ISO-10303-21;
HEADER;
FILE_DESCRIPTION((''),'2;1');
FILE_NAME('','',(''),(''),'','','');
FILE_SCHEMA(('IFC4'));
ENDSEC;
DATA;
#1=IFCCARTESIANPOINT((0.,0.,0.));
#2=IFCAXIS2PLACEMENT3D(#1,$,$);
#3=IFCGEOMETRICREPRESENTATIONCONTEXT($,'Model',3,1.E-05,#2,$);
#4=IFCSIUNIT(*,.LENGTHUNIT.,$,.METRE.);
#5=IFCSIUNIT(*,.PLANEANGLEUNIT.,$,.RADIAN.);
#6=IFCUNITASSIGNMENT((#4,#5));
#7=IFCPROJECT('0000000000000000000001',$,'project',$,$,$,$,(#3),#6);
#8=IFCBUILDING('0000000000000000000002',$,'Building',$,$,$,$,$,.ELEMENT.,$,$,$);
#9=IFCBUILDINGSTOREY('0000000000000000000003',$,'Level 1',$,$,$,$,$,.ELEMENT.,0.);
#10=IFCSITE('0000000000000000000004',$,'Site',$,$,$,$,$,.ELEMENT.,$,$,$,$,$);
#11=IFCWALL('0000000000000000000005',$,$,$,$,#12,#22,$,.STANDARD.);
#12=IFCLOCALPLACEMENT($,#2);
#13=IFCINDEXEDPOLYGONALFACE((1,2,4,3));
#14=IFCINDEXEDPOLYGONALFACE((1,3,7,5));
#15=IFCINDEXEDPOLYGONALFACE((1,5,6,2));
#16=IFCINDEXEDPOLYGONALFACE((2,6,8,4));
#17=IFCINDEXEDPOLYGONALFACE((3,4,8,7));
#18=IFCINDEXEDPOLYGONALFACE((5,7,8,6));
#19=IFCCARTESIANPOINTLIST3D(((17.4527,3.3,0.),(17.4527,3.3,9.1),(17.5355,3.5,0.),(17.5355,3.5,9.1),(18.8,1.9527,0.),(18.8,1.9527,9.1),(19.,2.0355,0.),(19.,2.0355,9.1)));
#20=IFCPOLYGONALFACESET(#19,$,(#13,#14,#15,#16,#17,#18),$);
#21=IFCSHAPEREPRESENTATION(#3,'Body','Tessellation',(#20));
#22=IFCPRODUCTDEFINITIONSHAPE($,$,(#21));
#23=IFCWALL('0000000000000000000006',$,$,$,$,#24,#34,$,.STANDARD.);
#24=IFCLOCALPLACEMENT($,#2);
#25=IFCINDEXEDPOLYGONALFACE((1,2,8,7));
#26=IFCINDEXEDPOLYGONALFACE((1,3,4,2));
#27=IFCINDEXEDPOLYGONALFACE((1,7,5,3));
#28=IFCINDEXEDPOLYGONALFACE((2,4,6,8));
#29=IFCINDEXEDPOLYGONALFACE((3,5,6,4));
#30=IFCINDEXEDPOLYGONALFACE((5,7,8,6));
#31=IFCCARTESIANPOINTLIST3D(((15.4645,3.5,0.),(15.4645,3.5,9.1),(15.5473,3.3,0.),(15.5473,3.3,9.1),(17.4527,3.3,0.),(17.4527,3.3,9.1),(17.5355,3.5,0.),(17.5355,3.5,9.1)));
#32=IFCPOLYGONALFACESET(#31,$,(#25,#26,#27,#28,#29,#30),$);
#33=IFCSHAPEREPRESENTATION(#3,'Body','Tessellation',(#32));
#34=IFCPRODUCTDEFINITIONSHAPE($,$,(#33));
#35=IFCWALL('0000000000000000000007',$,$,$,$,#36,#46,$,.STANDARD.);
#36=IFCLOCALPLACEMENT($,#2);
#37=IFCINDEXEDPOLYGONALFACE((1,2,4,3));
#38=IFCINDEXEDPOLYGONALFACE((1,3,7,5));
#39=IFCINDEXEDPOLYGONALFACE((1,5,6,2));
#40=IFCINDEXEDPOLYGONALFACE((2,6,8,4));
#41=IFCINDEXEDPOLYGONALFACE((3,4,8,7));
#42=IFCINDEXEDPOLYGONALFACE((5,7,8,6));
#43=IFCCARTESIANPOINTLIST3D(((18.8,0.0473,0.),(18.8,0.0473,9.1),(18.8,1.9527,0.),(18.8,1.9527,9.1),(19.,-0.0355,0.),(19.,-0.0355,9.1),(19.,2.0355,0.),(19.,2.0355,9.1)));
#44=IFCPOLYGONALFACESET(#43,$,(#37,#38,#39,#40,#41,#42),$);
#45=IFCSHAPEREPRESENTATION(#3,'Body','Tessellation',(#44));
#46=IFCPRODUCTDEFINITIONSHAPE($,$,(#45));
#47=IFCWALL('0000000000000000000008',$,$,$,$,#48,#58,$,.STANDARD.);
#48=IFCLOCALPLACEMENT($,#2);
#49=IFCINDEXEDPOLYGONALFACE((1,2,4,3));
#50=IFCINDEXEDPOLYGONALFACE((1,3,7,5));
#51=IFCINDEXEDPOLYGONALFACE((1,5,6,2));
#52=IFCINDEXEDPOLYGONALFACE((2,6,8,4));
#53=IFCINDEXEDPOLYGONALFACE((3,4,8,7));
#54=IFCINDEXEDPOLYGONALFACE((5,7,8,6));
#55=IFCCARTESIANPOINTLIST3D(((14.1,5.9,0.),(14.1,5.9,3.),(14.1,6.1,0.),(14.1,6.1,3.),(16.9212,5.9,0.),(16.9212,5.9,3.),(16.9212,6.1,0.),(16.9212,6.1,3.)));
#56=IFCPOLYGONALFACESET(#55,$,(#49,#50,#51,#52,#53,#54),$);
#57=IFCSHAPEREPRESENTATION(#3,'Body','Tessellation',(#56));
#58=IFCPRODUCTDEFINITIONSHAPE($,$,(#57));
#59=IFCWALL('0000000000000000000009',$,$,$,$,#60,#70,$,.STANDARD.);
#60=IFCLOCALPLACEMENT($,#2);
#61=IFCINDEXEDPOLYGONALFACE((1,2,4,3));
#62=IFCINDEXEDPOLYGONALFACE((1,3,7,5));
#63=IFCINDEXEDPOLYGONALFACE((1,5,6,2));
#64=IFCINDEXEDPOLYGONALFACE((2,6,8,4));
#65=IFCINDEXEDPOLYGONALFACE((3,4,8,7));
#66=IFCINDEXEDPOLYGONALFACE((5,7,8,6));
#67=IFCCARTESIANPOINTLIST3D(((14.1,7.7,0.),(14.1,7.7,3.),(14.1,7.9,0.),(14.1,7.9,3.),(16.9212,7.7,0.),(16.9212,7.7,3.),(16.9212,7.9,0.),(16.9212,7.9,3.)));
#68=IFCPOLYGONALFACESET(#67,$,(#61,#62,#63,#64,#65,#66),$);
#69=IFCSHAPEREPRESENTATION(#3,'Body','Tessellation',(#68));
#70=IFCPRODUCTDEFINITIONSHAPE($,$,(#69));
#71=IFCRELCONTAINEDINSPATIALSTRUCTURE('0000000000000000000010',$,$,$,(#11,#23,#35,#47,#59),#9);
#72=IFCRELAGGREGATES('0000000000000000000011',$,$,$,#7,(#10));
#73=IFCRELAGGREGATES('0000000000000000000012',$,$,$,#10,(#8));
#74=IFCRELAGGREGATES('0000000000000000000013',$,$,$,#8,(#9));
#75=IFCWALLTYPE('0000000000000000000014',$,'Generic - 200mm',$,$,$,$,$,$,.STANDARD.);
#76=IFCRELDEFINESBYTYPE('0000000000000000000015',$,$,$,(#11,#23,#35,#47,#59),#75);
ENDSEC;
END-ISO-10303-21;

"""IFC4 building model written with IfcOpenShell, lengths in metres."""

from ifc_helpers import new_model, si_unit, frame, frame_2d, origin, place, context, project, spatial, polyline, rectangle, outline, extrude, type_object, element, save


model = new_model("IFC4")

# Units and contexts
model_context = context("Model", 3, precision=1e-05, world=origin())
ifc_project = project(units=[si_unit("LENGTHUNIT", "METRE"), si_unit("PLANEANGLEUNIT", "RADIAN")], contexts=[model_context])

# Site, building, storey
site = spatial("IfcSite", under=ifc_project, Name="Site", CompositionType="ELEMENT")
building = spatial("IfcBuilding", under=site, Name="Building", CompositionType="ELEMENT")
storey = spatial("IfcBuildingStorey", under=building, Name="Level 1", CompositionType="ELEMENT", Elevation=0.0)

# Walls
wall_type_1 = type_object("IfcWallType", Name="Generic - 200mm", PredefinedType="STANDARD")
wall_1_placement = place(None, frame((17.4941, 3.4, 0.0), z_axis=(0.0, 0.0, 1.0), x_axis=(0.707107, -0.707107, 0.0)))
element("IfcWall", 1, at=wall_1_placement, inside=storey, type_object=wall_type_1, PredefinedType="STANDARD", context=model_context, shape_type="SweptSolid", body=[
    extrude(outline(polyline([(0.0414, -0.1), (1.9468, -0.1), (2.0296, 0.1), (-0.0414, 0.1), (0.0414, -0.1)])), origin(), (0.0, 0.0, 1.0), 9.1),
])
wall_2_placement = place(None, frame((15.5059, 3.4, 0.0), z_axis=(0.0, 0.0, 1.0), x_axis=(1.0, 0.0, 0.0)))
element("IfcWall", 2, at=wall_2_placement, inside=storey, type_object=wall_type_1, PredefinedType="STANDARD", context=model_context, shape_type="SweptSolid", body=[
    extrude(outline(polyline([(0.0414, -0.1), (1.9468, -0.1), (2.0296, 0.1), (-0.0414, 0.1), (0.0414, -0.1)])), origin(), (0.0, 0.0, 1.0), 9.1),
])

# Walls
wall_3_placement = place(None, frame((18.9, 1.9941, 0.0), z_axis=(0.0, 0.0, 1.0), x_axis=(0.0, -1.0, 0.0)))
element("IfcWall", 3, at=wall_3_placement, inside=storey, type_object=wall_type_1, PredefinedType="STANDARD", context=model_context, shape_type="SweptSolid", body=[
    extrude(outline(polyline([(0.0414, -0.1), (1.9468, -0.1), (2.0296, 0.1), (-0.0414, 0.1), (0.0414, -0.1)])), origin(), (0.0, 0.0, 1.0), 9.1),
])
for number, where, z_axis, x_axis in (
    (4, (16.9212, 6.0, 0.0), (0.0, 0.0, 1.0), (-1.0, 0.0, 0.0)),
    (5, (14.1, 7.8, 0.0), (0.0, 0.0, 1.0), (1.0, 0.0, 0.0)),
):
    element("IfcWall", number, at=place(None, frame(where, z_axis=z_axis, x_axis=x_axis)), inside=storey, type_object=wall_type_1, PredefinedType="STANDARD", context=model_context, shape_type="SweptSolid", body=[
        extrude(rectangle(XDim=2.8212, YDim=0.2, at=frame_2d((1.4106, 0.0))), origin(), (0.0, 0.0, 1.0), 3.0),
    ])

save(model, "model.ifc")
